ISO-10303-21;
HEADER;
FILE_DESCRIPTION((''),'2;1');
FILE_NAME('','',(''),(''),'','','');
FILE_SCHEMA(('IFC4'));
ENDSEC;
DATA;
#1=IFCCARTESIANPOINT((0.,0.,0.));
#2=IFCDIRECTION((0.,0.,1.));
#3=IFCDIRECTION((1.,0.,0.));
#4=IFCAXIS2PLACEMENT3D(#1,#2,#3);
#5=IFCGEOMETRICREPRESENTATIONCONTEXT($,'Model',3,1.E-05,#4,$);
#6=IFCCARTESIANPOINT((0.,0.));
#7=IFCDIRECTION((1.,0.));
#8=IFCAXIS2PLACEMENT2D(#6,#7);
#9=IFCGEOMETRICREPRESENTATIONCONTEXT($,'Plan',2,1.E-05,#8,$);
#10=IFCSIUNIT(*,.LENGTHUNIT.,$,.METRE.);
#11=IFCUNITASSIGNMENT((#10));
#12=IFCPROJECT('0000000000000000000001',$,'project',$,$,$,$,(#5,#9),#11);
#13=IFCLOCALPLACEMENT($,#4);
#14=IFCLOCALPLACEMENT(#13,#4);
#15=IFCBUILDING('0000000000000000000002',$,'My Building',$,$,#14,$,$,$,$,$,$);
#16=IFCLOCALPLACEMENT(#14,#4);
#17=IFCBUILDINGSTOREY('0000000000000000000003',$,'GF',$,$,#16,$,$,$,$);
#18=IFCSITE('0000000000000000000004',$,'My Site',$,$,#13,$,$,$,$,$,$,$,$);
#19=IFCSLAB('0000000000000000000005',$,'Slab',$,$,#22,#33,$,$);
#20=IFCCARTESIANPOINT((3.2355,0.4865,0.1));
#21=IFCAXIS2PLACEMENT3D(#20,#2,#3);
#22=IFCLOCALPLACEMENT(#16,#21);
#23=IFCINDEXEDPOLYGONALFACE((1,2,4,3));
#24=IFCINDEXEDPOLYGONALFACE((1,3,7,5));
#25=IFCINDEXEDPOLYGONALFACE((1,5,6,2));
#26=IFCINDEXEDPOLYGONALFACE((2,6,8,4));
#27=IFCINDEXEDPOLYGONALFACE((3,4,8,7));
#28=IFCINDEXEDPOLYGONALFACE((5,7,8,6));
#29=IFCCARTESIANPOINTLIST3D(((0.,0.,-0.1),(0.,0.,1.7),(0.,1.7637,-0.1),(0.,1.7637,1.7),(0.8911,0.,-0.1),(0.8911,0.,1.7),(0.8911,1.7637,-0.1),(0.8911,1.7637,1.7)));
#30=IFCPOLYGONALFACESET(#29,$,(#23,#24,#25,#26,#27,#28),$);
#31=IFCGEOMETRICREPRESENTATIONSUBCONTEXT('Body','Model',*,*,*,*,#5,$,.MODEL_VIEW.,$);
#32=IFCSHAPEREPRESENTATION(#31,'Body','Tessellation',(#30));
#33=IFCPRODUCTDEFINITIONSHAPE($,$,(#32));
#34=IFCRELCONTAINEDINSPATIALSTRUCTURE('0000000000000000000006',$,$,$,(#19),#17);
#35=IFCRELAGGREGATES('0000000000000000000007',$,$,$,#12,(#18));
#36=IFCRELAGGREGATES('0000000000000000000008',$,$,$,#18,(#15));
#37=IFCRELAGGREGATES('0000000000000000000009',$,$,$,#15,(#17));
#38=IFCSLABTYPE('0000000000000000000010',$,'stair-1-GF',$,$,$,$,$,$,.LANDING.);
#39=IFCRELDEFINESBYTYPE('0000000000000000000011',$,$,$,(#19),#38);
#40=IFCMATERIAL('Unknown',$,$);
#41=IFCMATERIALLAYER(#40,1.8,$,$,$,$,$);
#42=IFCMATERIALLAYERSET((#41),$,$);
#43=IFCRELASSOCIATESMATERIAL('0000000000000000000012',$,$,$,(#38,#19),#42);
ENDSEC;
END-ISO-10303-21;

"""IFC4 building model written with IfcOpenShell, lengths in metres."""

from ifc_helpers import new_model, si_unit, frame, origin_with_axes, origin_2d_with_axis, place, context, subcontext, project, spatial, indexed_curve, outline, extrude, material, layer, layer_set, layer_usage, type_object, element, save


model = new_model("IFC4")

# Units and contexts
model_context = context("Model", 3, precision=1e-05, world=origin_with_axes())
plan_context = context("Plan", 2, precision=1e-05, world=origin_2d_with_axis())
body_context_1 = subcontext(model_context, "Body", "Model", "MODEL_VIEW")
ifc_project = project(units=[si_unit("LENGTHUNIT", "METRE")], contexts=[model_context, plan_context])

# Site, building, storey
site_placement = place(None, origin_with_axes())
site = spatial("IfcSite", under=ifc_project, at=site_placement, Name="My Site")
building_placement = place(site_placement, origin_with_axes())
building = spatial("IfcBuilding", under=site, at=building_placement, Name="My Building")
storey_placement = place(building_placement, origin_with_axes())
storey = spatial("IfcBuildingStorey", under=building, at=storey_placement, Name="GF")

# Slab
ifc_material_1 = material(Name="Unknown")
ifc_layer_1 = layer(ifc_material_1, 1.8)
ifc_layer_set_1 = layer_set([ifc_layer_1])
slab_type_1 = type_object("IfcSlabType", Name="stair-1-GF", PredefinedType="LANDING", material=ifc_layer_set_1)
ifc_layer_usage_1 = layer_usage(ifc_layer_set_1, "AXIS3", "POSITIVE", -0.1)
slab_1_placement = place(storey_placement, frame((3.2355, 0.4865, 0.1), z_axis=(0.0, 0.0, 1.0), x_axis=(1.0, 0.0, 0.0)))
element("IfcSlab", 1, at=slab_1_placement, inside=storey, type_object=slab_type_1, material=ifc_layer_usage_1, Name="Slab", context=body_context_1, shape_type="SweptSolid", body=[
    extrude(outline(indexed_curve([(0.0, 0.0), (0.0, 1.7637), (0.8911, 1.7637), (0.8911, 0.0), (0.0, 0.0)])), frame((0.0, 0.0, -0.1), z_axis=(0.0, 0.0, 1.0), x_axis=(1.0, 0.0, 0.0)), (0.0, 0.0, 1.0), 1.8),
])

save(model, "model.ifc")
